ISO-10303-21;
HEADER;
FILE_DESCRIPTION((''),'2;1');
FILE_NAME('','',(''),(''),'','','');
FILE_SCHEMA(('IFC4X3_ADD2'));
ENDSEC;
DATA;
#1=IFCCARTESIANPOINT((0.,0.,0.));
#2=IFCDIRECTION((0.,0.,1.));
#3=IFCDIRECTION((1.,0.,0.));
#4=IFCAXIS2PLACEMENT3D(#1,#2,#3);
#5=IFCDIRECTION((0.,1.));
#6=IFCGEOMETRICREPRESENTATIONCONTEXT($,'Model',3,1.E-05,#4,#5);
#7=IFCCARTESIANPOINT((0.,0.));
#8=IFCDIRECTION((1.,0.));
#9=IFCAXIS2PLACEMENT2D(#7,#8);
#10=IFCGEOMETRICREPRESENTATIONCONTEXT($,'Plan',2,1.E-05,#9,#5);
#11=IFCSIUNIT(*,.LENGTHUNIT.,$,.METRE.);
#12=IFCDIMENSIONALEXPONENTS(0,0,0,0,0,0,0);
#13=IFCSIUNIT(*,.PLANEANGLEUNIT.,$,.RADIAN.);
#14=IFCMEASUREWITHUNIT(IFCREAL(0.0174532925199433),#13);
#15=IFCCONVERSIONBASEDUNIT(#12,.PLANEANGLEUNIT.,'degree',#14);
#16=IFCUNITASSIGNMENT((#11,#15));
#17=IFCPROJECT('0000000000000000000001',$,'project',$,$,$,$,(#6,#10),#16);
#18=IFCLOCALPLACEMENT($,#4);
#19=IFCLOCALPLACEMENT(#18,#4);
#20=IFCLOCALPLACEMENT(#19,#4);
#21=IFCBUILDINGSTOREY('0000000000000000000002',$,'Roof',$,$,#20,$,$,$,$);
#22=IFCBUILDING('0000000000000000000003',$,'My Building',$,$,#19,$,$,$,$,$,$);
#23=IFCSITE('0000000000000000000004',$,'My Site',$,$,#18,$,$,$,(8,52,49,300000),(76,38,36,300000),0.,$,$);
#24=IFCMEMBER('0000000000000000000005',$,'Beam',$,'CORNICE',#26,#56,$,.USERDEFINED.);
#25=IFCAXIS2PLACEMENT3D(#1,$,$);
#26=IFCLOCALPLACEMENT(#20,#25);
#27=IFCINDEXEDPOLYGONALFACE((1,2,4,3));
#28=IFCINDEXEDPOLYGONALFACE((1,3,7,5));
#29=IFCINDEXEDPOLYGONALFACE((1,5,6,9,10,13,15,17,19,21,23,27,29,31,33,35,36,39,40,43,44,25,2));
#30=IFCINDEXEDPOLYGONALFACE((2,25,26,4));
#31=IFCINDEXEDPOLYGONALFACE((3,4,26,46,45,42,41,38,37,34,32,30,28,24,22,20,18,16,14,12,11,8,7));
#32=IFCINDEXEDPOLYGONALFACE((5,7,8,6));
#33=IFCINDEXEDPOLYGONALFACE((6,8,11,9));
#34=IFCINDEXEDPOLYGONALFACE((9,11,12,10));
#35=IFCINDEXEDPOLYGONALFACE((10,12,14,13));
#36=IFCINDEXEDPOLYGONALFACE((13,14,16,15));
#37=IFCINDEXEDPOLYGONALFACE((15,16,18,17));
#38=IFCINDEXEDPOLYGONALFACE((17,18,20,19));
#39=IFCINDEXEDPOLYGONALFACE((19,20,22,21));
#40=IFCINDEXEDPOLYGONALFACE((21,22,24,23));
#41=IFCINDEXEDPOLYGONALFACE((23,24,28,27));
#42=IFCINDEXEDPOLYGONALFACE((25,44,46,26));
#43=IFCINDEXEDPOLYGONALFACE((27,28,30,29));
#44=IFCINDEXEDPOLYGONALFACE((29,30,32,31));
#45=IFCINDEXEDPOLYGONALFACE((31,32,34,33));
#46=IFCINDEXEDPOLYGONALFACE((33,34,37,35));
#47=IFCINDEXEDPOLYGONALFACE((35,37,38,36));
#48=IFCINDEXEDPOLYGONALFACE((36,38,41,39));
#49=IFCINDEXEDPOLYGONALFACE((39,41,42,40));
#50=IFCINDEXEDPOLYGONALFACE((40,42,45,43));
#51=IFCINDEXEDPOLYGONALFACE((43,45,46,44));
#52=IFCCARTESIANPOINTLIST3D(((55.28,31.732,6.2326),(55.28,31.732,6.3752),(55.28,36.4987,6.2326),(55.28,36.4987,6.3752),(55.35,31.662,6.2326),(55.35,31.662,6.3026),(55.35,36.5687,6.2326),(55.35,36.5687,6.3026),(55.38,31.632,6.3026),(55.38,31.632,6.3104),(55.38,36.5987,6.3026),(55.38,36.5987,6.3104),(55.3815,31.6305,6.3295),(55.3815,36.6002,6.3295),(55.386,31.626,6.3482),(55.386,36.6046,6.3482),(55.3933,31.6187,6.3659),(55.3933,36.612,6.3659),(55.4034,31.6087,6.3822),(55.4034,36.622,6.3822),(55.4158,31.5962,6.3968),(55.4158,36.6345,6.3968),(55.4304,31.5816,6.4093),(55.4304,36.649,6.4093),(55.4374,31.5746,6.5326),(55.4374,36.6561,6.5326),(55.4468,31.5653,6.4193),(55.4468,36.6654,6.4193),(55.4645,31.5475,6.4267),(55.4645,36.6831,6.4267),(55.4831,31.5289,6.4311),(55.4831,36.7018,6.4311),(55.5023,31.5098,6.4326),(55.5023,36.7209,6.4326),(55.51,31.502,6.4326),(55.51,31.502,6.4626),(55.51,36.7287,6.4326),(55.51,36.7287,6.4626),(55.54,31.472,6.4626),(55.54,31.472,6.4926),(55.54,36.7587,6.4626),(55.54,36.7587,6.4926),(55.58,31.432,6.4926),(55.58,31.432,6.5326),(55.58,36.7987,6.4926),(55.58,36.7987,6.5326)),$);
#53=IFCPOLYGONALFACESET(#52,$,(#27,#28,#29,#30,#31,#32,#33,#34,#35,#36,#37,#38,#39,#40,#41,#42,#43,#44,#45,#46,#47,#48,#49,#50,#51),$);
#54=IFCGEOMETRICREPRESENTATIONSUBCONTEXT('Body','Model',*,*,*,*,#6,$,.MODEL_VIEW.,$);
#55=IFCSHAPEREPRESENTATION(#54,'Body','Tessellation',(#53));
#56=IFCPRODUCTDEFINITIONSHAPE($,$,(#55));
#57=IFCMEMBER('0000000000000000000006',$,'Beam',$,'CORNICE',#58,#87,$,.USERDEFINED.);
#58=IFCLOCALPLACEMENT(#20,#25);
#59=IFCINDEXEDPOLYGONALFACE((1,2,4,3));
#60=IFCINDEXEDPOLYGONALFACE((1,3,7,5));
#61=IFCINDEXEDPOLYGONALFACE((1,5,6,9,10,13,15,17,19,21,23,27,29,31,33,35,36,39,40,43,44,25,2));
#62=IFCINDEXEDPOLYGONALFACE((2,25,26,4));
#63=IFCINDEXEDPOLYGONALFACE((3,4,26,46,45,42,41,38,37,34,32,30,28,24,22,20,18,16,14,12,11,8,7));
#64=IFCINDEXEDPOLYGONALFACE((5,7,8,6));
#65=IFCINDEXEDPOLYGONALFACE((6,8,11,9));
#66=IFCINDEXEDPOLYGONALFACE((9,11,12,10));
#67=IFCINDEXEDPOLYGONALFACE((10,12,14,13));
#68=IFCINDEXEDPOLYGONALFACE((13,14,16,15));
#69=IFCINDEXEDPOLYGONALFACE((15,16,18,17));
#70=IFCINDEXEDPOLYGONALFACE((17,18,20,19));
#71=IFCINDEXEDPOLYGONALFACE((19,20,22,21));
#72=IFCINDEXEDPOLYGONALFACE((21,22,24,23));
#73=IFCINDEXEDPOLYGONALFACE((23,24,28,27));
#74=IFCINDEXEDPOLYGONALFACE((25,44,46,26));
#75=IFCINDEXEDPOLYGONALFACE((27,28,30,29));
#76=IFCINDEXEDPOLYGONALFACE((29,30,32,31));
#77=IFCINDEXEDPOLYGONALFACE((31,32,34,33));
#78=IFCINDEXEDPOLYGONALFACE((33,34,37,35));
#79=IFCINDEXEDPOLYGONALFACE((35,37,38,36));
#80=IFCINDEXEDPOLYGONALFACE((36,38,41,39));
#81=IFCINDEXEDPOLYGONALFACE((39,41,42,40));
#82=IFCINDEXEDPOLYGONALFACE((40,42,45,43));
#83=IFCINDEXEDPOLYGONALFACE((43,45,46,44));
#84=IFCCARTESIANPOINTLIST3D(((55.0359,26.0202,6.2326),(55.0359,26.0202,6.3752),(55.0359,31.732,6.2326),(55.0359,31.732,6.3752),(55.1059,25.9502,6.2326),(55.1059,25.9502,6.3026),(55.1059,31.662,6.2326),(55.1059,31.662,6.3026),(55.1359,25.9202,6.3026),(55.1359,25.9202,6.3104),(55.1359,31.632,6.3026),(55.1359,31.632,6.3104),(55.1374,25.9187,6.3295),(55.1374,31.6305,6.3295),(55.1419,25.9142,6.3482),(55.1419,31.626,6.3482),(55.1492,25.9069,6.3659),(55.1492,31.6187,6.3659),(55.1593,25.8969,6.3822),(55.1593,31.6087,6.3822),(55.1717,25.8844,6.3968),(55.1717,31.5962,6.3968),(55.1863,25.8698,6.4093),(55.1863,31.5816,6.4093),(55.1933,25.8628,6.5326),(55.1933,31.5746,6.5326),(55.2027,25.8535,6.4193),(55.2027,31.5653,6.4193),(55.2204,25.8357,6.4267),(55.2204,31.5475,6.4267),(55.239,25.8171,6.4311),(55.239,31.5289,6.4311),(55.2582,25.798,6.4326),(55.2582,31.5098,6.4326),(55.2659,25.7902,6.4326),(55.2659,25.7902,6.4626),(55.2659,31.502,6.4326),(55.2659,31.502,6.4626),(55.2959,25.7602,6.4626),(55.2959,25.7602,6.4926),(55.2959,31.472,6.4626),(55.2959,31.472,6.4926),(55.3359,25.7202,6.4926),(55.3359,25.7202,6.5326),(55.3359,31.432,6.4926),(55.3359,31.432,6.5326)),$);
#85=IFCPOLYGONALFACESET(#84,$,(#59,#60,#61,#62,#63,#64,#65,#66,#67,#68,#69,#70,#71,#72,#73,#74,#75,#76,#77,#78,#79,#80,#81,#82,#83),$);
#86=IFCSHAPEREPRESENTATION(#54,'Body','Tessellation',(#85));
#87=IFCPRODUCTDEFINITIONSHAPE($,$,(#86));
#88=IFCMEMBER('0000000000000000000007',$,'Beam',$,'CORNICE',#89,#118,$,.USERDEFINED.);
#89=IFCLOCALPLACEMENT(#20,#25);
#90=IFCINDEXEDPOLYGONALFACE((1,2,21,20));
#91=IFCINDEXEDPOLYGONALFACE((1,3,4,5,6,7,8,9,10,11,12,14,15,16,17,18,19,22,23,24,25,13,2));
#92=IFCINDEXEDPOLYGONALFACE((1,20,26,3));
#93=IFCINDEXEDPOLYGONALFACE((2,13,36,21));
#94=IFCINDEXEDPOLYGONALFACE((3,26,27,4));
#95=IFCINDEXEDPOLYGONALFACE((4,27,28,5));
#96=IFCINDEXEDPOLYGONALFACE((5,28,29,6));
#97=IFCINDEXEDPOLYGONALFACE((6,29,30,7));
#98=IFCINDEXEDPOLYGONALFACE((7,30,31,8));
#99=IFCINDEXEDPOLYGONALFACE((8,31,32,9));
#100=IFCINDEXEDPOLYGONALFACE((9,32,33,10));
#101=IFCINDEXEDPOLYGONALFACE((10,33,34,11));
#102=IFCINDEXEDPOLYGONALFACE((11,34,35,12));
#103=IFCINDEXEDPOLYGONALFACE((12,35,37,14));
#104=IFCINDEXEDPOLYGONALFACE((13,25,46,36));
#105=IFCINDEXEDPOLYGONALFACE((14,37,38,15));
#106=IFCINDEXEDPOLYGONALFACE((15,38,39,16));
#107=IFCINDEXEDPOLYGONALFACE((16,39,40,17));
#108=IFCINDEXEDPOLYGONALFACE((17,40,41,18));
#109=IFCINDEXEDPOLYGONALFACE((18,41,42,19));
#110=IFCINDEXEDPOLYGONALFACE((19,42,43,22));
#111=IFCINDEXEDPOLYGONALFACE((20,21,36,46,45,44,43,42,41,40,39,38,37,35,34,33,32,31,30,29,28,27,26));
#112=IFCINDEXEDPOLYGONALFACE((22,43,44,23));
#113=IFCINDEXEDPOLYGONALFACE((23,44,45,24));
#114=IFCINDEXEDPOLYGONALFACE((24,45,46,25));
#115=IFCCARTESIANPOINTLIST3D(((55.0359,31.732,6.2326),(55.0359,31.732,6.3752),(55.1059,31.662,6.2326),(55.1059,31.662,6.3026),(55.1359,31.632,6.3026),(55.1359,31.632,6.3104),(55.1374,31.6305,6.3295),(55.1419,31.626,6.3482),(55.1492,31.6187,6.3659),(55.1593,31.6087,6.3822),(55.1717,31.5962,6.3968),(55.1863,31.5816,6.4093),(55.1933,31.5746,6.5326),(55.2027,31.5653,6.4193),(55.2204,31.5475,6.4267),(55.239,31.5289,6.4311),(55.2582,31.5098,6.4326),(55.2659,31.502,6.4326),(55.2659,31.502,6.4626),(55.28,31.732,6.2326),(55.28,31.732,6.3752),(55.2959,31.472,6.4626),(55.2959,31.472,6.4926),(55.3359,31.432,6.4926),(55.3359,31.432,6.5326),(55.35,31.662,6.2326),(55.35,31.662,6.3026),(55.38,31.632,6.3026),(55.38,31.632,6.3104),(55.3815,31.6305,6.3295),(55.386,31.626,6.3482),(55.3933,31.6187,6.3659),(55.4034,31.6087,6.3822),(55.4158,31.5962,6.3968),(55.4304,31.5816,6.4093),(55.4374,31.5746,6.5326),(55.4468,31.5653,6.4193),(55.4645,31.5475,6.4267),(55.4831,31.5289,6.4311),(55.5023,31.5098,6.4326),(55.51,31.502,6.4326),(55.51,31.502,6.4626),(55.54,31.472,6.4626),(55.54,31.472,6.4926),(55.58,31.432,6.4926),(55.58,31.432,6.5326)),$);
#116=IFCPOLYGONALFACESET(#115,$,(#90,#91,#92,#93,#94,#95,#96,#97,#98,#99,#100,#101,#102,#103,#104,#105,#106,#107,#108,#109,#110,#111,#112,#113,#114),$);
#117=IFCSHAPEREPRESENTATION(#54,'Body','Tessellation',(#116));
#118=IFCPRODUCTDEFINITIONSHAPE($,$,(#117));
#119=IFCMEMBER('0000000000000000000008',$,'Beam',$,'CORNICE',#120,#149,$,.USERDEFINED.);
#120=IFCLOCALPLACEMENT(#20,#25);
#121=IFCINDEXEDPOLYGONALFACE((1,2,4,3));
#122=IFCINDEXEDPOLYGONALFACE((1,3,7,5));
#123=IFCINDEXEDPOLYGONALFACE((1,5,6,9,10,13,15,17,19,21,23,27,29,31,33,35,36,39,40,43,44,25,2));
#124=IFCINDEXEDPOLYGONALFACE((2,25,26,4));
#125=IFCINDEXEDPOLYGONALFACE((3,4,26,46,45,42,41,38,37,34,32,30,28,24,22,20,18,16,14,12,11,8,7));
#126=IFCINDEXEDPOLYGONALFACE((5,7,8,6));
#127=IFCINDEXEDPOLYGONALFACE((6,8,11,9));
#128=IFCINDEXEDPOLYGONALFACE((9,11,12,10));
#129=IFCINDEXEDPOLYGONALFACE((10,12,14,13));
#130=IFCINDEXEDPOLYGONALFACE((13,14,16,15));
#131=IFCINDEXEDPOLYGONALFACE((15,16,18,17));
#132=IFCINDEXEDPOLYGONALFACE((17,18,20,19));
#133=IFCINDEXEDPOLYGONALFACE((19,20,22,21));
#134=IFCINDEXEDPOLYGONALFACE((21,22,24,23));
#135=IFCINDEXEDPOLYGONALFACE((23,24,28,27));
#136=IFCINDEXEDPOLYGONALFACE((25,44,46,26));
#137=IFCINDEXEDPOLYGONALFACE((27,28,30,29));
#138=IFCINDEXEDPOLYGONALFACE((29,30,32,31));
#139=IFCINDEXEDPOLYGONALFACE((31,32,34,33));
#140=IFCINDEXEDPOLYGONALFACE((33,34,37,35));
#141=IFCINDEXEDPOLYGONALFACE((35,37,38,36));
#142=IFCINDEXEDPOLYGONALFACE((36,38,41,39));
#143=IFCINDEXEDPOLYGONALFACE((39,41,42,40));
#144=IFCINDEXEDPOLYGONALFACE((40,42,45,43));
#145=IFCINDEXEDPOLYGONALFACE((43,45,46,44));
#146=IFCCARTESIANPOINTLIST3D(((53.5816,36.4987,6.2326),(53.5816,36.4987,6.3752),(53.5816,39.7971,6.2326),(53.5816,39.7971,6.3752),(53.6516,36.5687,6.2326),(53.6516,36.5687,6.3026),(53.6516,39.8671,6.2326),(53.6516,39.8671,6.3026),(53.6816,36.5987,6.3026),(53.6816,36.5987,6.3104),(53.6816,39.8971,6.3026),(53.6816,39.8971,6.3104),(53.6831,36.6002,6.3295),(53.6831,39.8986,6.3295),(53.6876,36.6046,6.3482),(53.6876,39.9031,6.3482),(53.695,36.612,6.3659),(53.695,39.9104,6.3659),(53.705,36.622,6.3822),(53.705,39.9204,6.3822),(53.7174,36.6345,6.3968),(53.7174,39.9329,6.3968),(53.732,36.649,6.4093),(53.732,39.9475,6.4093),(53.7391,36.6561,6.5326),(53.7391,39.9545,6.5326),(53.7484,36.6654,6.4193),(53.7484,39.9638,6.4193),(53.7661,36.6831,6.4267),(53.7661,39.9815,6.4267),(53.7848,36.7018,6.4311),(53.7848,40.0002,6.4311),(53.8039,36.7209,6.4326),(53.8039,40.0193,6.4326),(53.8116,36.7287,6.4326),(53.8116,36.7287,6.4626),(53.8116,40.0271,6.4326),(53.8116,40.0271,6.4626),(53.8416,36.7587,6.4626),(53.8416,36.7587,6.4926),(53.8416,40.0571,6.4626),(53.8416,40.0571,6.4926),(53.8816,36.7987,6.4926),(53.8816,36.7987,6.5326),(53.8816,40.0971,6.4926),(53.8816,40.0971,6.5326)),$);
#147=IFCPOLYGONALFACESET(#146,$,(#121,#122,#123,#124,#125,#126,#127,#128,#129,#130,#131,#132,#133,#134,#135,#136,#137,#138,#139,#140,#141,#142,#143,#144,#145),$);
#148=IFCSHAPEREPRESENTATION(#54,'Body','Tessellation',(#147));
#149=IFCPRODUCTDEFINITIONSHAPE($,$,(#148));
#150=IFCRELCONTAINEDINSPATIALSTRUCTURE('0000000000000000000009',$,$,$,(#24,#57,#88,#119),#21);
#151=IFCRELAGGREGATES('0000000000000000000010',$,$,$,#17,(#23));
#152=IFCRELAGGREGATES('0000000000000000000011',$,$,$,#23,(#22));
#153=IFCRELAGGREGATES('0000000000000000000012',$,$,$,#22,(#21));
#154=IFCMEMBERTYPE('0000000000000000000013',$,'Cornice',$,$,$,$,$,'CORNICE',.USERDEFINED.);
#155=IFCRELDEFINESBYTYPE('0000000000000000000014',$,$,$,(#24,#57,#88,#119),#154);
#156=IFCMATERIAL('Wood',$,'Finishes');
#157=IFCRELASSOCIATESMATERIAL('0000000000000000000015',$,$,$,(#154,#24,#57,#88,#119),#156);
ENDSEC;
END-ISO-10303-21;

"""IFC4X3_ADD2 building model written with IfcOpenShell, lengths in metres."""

from ifc_helpers import new_model, entity, si_unit, converted_unit, direction, frame, origin_with_axes, origin_2d_with_axis, place, context, subcontext, project, spatial, indexed_curve, outline, extrude, clip, halfspace, material, material_profile, profile_set, profile_usage, type_object, element, save


model = new_model("IFC4X3_ADD2")

# Units and contexts
model_context = context("Model", 3, precision=1e-05, world=origin_with_axes(), true_north=direction((0.0, 1.0)))
plan_context = context("Plan", 2, precision=1e-05, world=origin_2d_with_axis(), true_north=direction((0.0, 1.0)))
body_context = subcontext(model_context, "Body", "Model", "MODEL_VIEW")
ifc_project = project(units=[si_unit("LENGTHUNIT", "METRE"), converted_unit("PLANEANGLEUNIT", "degree", entity("IfcReal", 0.0174532925199433), si_unit("PLANEANGLEUNIT", "RADIAN"), dimensions=[0, 0, 0, 0, 0, 0, 0])], contexts=[model_context, plan_context])

# Site, building, storey
site_placement = place(None, origin_with_axes())
site = spatial("IfcSite", under=ifc_project, at=site_placement, Name="My Site", RefLatitude=(8, 52, 49, 300000), RefLongitude=(76, 38, 36, 300000), RefElevation=0.0)
building_placement = place(site_placement, origin_with_axes())
building = spatial("IfcBuilding", under=site, at=building_placement, Name="My Building")
storey_placement = place(building_placement, origin_with_axes())
storey = spatial("IfcBuildingStorey", under=building, at=storey_placement, Name="Roof")

# Members
ifc_material_1 = material(Name="Wood", Category="Finishes")
ifc_material_profile_1 = material_profile(ifc_material_1, outline(indexed_curve([(-0.26, 0.26), (-0.3, 0.26), (-0.3, 0.3), (-0.1574, 0.3), (0.0, 0.1426), (0.0, 0.0), (-0.07, 0.0), (-0.07, 0.07), (-0.1, 0.07), (-0.1, 0.0777), (-0.1015, 0.0969), (-0.106, 0.1155), (-0.1133, 0.1332), (-0.1233, 0.1496), (-0.1358, 0.1642), (-0.1504, 0.1767), (-0.1668, 0.1867), (-0.1845, 0.194), (-0.2031, 0.1985), (-0.2223, 0.2), (-0.23, 0.2), (-0.23, 0.23), (-0.26, 0.23), (-0.26, 0.26)])))
ifc_profile_set_1 = profile_set([ifc_material_profile_1])
ifc_profile_usage_1 = profile_usage(ifc_profile_set_1, cardinal=5)
member_type = type_object("IfcMemberType", Name="Cornice", ElementType="CORNICE", PredefinedType="USERDEFINED", material=ifc_profile_set_1)
member_1_placement = place(storey_placement, frame((55.28, 31.432, 6.2326), z_axis=(0.0, 1.0, 0.0), x_axis=(-1.0, 0.0, 0.0)))
element("IfcMember", 1, at=member_1_placement, inside=storey, type_object=member_type, material=ifc_profile_usage_1, Name="Beam", ObjectType="CORNICE", PredefinedType="USERDEFINED", context=body_context, shape_type="Clipping", body=[
    clip(clip(extrude(outline(indexed_curve([(-0.26, 0.26), (-0.3, 0.26), (-0.3, 0.3), (-0.1574, 0.3), (0.0, 0.1426), (0.0, 0.0), (-0.07, 0.0), (-0.07, 0.07), (-0.1, 0.07), (-0.1, 0.0777), (-0.1015, 0.0969), (-0.106, 0.1155), (-0.1133, 0.1332), (-0.1233, 0.1496), (-0.1358, 0.1642), (-0.1504, 0.1767), (-0.1668, 0.1867), (-0.1845, 0.194), (-0.2031, 0.1985), (-0.2223, 0.2), (-0.23, 0.2), (-0.23, 0.23), (-0.26, 0.23), (-0.26, 0.26)])), origin_with_axes(), (0.0, 0.0, 1.0), 5.3666), halfspace(frame((-0.3, -6.1726, 0.0), z_axis=(0.707107, 0.0, -0.707107), x_axis=(0.0, -1.0, 0.0)), False)), halfspace(frame((-0.3, -6.1726, 5.3666), z_axis=(0.707107, 0.0, 0.707107), x_axis=(0.0, -1.0, 0.0)), False)),
])
ifc_profile_usage_2 = profile_usage(ifc_profile_set_1, cardinal=5)
member_2_placement = place(storey_placement, frame((55.0359, 25.7202, 6.2326), z_axis=(0.0, 1.0, 0.0), x_axis=(-1.0, 0.0, 0.0)))
element("IfcMember", 2, at=member_2_placement, inside=storey, type_object=member_type, material=ifc_profile_usage_2, Name="Beam", ObjectType="CORNICE", PredefinedType="USERDEFINED", context=body_context, shape_type="Clipping", body=[
    clip(clip(extrude(outline(indexed_curve([(-0.26, 0.26), (-0.3, 0.26), (-0.3, 0.3), (-0.1574, 0.3), (0.0, 0.1426), (0.0, 0.0), (-0.07, 0.0), (-0.07, 0.07), (-0.1, 0.07), (-0.1, 0.0777), (-0.1015, 0.0969), (-0.106, 0.1155), (-0.1133, 0.1332), (-0.1233, 0.1496), (-0.1358, 0.1642), (-0.1504, 0.1767), (-0.1668, 0.1867), (-0.1845, 0.194), (-0.2031, 0.1985), (-0.2223, 0.2), (-0.23, 0.2), (-0.23, 0.23), (-0.26, 0.23), (-0.26, 0.26)])), origin_with_axes(), (0.0, 0.0, 1.0), 6.0118), halfspace(frame((-0.3, -6.1726, 0.0), z_axis=(0.707107, 0.0, -0.707107), x_axis=(0.0, -1.0, 0.0)), False)), halfspace(frame((0.0, -6.1726, 6.0118), z_axis=(-0.707107, 0.0, 0.707107), x_axis=(0.0, 1.0, 0.0)), False)),
])
ifc_profile_usage_3 = profile_usage(ifc_profile_set_1, cardinal=5)
member_3_placement = place(storey_placement, frame((55.0359, 31.732, 6.2326), z_axis=(1.0, 0.0, 0.0), x_axis=(0.0, 1.0, 0.0)))
element("IfcMember", 3, at=member_3_placement, inside=storey, type_object=member_type, material=ifc_profile_usage_3, Name="Beam", ObjectType="CORNICE", PredefinedType="USERDEFINED", context=body_context, shape_type="Clipping", body=[
    clip(clip(extrude(outline(indexed_curve([(-0.26, 0.26), (-0.3, 0.26), (-0.3, 0.3), (-0.1574, 0.3), (0.0, 0.1426), (0.0, 0.0), (-0.07, 0.0), (-0.07, 0.07), (-0.1, 0.07), (-0.1, 0.0777), (-0.1015, 0.0969), (-0.106, 0.1155), (-0.1133, 0.1332), (-0.1233, 0.1496), (-0.1358, 0.1642), (-0.1504, 0.1767), (-0.1668, 0.1867), (-0.1845, 0.194), (-0.2031, 0.1985), (-0.2223, 0.2), (-0.23, 0.2), (-0.23, 0.23), (-0.26, 0.23), (-0.26, 0.26)])), origin_with_axes(), (0.0, 0.0, 1.0), 0.5441), halfspace(frame((0.0, -6.1726, 0.0), z_axis=(-0.707107, 0.0, -0.707107), x_axis=(0.0, 1.0, 0.0)), False)), halfspace(frame((-0.3, -6.1726, 0.5441), z_axis=(0.707107, 0.0, 0.707107), x_axis=(0.0, -1.0, 0.0)), False)),
])
ifc_profile_usage_4 = profile_usage(ifc_profile_set_1, cardinal=5)
member_4_placement = place(storey_placement, frame((53.5816, 36.4987, 6.2326), z_axis=(0.0, 1.0, 0.0), x_axis=(-1.0, 0.0, 0.0)))
element("IfcMember", 4, at=member_4_placement, inside=storey, type_object=member_type, material=ifc_profile_usage_4, Name="Beam", ObjectType="CORNICE", PredefinedType="USERDEFINED", context=body_context, shape_type="Clipping", body=[
    clip(clip(extrude(outline(indexed_curve([(-0.26, 0.26), (-0.3, 0.26), (-0.3, 0.3), (-0.1574, 0.3), (0.0, 0.1426), (0.0, 0.0), (-0.07, 0.0), (-0.07, 0.07), (-0.1, 0.07), (-0.1, 0.0777), (-0.1015, 0.0969), (-0.106, 0.1155), (-0.1133, 0.1332), (-0.1233, 0.1496), (-0.1358, 0.1642), (-0.1504, 0.1767), (-0.1668, 0.1867), (-0.1845, 0.194), (-0.2031, 0.1985), (-0.2223, 0.2), (-0.23, 0.2), (-0.23, 0.23), (-0.26, 0.23), (-0.26, 0.26)])), origin_with_axes(), (0.0, 0.0, 1.0), 3.5984), halfspace(frame((-0.3, -6.1726, 3.5984), z_axis=(0.707107, 0.0, 0.707107), x_axis=(0.0, -1.0, 0.0)), False)), halfspace(frame((0.0, -6.1726, 0.0), z_axis=(-0.707107, 0.0, -0.707107), x_axis=(0.0, 1.0, 0.0)), False)),
])

save(model, "model.ifc")
